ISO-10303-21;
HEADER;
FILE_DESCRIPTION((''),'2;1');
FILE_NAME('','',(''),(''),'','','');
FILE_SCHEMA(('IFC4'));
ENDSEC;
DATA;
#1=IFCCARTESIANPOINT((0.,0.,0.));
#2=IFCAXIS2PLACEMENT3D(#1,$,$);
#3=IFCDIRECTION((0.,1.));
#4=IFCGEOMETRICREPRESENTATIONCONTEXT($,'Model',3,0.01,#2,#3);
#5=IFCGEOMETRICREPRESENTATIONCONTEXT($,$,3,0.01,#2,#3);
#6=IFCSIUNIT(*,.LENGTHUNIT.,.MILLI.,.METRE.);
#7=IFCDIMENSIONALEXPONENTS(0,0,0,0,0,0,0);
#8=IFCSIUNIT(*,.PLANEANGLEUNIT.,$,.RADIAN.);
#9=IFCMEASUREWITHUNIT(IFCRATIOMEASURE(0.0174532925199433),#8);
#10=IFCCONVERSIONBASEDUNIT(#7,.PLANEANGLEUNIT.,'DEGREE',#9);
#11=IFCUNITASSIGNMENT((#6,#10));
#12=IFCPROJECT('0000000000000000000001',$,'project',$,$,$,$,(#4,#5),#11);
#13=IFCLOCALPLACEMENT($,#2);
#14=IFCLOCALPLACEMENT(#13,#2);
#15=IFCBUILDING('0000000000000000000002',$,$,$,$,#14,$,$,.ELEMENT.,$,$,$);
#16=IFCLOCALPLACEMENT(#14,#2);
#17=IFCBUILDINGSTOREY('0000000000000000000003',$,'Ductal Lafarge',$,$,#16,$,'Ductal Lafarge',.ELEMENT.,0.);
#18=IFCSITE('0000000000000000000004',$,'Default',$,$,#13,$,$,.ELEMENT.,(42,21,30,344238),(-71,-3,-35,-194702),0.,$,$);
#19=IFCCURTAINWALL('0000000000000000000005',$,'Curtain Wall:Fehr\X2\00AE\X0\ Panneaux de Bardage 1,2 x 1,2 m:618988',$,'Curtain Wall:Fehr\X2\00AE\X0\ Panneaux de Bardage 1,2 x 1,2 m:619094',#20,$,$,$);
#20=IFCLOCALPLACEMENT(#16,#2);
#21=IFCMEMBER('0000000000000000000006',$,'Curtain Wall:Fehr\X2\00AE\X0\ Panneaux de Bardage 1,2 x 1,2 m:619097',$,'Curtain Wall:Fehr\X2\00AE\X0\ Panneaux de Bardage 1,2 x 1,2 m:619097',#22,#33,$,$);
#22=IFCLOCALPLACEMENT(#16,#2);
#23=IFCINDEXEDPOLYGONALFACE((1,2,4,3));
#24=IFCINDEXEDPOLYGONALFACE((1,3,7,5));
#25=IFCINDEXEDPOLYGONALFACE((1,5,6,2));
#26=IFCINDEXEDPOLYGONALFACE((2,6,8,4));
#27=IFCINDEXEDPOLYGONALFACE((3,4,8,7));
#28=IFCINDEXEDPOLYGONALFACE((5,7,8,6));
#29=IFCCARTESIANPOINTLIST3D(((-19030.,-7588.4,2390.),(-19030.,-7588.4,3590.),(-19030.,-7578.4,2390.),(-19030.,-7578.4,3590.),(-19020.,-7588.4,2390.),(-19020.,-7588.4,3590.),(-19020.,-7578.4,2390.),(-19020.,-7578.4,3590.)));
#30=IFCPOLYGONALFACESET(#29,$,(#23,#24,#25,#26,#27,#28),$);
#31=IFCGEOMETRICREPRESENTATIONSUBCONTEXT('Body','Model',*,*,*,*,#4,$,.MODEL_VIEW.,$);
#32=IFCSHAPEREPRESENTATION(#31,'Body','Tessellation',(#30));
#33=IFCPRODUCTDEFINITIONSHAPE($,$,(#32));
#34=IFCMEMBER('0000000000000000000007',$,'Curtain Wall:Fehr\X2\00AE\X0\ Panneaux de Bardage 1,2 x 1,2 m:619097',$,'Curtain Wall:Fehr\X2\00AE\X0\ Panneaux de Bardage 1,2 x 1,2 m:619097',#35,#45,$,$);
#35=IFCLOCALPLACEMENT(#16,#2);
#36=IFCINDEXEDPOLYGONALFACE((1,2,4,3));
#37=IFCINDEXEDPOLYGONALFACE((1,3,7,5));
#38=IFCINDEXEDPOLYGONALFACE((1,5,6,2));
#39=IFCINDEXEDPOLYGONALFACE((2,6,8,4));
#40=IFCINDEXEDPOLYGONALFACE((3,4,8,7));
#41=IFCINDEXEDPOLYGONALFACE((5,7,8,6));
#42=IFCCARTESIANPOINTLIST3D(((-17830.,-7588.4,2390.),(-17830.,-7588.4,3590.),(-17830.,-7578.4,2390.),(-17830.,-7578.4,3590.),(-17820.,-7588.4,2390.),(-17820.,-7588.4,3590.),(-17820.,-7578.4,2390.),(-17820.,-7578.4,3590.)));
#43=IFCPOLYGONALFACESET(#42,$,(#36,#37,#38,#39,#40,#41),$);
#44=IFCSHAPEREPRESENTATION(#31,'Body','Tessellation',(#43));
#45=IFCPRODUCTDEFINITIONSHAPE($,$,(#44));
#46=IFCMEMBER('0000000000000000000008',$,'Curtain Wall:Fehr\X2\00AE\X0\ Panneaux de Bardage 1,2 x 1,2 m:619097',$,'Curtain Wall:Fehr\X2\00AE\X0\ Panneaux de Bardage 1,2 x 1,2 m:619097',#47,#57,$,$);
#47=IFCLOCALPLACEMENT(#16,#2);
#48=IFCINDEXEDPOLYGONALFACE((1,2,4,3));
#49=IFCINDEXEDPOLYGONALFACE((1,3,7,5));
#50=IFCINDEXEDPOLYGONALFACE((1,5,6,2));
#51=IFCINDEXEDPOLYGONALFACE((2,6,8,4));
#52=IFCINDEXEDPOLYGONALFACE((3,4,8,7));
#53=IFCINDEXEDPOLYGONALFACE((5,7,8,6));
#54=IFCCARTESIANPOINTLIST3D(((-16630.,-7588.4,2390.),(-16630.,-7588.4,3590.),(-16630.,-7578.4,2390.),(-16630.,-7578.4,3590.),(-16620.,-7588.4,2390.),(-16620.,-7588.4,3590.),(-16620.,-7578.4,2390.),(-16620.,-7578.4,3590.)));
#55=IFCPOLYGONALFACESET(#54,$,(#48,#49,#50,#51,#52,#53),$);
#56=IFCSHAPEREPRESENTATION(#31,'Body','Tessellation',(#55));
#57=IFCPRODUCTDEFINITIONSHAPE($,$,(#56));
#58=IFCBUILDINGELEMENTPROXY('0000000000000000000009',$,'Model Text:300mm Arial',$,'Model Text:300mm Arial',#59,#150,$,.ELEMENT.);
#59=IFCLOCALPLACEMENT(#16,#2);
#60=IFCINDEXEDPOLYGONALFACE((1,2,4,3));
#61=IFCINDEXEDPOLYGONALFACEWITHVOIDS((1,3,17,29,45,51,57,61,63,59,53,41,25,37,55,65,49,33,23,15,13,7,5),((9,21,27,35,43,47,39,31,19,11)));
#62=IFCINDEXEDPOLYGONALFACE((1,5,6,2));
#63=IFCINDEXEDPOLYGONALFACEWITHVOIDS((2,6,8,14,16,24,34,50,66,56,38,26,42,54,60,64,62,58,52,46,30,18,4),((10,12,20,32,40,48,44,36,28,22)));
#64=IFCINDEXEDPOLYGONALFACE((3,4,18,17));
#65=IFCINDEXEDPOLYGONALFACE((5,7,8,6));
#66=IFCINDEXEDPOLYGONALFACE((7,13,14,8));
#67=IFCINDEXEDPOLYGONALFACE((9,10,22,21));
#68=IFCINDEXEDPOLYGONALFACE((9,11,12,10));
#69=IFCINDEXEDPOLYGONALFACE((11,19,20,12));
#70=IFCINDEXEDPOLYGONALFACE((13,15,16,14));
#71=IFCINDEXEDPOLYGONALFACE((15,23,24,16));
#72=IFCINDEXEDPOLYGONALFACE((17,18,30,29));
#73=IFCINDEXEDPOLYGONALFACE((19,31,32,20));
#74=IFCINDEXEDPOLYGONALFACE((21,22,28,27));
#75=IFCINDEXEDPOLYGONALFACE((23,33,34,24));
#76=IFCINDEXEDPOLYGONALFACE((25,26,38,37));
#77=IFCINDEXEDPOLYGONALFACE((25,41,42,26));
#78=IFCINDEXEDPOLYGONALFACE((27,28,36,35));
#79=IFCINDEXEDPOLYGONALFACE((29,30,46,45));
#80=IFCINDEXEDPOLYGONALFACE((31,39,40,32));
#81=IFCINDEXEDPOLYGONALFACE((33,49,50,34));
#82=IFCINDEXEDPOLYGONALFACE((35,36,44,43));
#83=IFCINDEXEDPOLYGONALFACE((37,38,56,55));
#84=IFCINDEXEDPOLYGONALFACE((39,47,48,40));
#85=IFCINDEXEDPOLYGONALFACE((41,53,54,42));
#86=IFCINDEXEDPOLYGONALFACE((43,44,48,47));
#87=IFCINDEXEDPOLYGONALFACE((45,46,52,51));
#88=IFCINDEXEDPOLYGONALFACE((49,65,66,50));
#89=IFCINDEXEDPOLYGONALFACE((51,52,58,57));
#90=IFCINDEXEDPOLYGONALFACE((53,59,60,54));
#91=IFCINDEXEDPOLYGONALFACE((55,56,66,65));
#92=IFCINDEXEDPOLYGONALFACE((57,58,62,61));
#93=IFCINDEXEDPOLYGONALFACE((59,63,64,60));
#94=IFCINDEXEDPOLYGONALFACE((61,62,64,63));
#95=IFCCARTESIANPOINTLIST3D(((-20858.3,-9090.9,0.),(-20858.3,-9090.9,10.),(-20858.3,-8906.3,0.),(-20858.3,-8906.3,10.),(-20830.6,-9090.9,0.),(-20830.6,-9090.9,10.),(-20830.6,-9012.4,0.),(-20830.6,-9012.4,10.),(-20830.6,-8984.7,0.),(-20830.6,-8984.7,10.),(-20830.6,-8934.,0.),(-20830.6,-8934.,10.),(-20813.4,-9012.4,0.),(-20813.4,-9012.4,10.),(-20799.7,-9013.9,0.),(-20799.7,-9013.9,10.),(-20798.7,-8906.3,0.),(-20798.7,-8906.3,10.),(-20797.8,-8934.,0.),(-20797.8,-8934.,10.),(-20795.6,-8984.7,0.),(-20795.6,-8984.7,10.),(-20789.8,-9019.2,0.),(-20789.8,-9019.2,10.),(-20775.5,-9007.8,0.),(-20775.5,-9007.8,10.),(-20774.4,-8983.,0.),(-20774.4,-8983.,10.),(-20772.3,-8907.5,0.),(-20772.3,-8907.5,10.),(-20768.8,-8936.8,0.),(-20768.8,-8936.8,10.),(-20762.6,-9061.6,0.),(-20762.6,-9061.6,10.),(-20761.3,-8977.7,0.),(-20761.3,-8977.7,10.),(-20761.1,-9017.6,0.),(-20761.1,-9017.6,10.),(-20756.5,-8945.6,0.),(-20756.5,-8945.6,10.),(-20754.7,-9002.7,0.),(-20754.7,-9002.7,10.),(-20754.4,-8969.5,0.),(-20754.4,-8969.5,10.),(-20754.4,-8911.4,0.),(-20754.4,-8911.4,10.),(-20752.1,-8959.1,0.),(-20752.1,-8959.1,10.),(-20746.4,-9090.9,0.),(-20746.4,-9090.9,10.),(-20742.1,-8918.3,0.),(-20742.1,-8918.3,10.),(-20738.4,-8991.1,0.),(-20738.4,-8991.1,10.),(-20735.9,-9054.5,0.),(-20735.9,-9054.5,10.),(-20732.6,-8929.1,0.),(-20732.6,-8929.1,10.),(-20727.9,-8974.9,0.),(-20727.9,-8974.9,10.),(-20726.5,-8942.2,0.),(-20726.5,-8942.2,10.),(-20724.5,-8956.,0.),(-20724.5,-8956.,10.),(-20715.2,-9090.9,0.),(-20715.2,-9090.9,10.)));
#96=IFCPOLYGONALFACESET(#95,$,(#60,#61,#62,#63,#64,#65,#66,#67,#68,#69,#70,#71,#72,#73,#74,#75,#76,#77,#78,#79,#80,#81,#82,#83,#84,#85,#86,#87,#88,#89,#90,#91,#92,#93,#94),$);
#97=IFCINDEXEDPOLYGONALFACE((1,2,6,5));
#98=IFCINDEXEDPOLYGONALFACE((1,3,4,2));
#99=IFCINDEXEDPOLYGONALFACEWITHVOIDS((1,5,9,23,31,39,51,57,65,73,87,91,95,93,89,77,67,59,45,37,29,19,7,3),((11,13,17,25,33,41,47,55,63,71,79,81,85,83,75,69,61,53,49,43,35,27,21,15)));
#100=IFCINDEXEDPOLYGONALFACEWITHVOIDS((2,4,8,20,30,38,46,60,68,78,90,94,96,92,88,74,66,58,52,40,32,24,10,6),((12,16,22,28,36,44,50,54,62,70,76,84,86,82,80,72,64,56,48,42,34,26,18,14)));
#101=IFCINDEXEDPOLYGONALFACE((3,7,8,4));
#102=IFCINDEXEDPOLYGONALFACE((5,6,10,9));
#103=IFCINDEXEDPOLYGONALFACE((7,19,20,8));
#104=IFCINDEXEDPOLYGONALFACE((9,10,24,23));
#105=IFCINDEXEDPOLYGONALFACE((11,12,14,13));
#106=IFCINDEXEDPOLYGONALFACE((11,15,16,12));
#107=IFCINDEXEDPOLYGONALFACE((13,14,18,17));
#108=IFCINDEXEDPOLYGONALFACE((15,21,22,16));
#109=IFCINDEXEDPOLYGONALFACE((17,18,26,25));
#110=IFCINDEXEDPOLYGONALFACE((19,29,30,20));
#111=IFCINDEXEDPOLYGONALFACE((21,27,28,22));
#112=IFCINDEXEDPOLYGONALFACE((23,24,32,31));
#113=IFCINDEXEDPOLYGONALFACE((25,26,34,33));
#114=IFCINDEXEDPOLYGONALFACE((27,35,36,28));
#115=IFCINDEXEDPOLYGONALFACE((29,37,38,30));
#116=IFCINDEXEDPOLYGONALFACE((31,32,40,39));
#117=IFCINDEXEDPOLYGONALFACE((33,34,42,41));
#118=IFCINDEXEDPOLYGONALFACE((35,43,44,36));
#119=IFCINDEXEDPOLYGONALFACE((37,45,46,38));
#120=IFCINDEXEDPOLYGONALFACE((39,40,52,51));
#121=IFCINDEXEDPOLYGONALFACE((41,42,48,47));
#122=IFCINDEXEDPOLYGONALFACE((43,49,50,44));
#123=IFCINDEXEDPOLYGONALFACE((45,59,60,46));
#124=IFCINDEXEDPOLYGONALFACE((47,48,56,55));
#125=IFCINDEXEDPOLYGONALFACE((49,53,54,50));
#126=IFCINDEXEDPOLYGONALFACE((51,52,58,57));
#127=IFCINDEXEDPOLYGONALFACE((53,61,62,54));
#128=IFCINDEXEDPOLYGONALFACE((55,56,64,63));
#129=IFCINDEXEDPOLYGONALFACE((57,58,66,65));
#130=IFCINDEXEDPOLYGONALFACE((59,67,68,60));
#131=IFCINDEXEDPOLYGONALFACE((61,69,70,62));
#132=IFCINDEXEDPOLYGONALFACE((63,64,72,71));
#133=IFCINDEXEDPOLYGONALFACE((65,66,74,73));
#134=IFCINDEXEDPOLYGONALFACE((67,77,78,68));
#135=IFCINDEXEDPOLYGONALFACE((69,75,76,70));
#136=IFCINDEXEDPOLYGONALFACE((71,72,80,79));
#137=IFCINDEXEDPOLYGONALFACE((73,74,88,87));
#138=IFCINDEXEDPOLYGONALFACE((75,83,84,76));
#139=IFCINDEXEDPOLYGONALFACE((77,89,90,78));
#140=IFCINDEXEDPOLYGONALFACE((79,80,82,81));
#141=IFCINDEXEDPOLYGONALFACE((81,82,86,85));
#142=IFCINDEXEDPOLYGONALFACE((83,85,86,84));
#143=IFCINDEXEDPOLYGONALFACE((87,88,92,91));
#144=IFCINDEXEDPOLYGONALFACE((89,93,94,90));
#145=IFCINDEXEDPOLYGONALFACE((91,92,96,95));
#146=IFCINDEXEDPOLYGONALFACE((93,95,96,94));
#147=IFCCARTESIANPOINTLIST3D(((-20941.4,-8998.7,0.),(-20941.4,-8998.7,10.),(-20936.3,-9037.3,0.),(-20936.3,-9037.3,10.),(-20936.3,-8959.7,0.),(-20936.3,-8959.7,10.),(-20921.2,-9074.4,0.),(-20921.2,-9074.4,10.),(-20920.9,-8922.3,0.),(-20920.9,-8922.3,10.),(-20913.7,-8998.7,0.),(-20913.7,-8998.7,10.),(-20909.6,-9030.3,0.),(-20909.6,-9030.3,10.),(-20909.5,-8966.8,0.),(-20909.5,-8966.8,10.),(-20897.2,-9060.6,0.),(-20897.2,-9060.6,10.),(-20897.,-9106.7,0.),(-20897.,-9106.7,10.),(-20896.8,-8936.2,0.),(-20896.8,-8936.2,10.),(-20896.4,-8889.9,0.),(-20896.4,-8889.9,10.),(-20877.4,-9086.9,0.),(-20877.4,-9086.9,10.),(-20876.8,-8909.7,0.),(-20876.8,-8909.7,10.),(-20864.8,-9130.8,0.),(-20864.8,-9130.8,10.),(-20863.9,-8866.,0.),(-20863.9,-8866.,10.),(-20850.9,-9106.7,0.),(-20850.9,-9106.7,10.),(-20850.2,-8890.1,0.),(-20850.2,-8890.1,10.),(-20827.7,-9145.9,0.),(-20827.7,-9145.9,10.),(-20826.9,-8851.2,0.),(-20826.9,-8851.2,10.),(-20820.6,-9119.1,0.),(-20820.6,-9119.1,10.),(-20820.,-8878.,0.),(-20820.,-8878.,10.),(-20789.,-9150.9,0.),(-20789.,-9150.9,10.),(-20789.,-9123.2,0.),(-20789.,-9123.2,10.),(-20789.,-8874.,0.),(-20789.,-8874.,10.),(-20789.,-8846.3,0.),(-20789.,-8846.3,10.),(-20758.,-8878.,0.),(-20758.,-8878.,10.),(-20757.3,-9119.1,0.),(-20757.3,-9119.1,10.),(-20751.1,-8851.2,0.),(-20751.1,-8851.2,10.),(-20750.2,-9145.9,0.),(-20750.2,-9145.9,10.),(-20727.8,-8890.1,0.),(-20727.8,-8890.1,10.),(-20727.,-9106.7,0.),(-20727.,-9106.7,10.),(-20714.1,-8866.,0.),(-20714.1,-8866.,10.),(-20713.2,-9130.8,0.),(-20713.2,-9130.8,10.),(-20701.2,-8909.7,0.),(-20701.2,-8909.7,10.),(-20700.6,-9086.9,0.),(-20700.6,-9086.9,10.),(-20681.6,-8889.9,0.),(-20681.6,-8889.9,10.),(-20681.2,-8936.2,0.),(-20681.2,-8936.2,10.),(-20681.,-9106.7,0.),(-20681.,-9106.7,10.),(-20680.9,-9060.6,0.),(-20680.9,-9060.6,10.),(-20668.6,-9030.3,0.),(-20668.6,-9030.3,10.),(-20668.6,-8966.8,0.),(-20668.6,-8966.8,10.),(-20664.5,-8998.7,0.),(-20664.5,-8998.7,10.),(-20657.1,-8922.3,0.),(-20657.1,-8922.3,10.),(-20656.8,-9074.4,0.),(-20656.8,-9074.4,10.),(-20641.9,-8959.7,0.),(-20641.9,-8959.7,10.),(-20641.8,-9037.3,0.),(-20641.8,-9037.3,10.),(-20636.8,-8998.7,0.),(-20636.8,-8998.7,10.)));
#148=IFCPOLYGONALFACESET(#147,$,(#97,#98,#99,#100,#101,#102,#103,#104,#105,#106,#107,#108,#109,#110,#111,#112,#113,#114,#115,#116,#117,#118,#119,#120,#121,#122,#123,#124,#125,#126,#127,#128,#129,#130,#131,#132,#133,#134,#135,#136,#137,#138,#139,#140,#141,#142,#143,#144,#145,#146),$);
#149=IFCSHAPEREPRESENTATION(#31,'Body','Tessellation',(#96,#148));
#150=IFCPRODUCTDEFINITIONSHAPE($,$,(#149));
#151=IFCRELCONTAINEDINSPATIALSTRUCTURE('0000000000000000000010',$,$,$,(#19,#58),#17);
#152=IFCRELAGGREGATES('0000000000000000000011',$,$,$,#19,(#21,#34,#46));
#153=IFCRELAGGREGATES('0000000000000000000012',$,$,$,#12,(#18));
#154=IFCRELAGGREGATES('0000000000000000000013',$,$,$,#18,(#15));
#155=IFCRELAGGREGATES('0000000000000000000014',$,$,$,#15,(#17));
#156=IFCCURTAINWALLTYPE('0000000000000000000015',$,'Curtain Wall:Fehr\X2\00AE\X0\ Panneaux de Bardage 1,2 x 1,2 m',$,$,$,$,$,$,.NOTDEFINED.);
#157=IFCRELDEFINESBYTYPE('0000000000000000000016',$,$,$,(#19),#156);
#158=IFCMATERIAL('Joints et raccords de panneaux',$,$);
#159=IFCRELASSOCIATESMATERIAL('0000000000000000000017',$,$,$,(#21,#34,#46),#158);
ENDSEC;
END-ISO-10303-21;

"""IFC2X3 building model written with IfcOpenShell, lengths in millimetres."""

from ifc_helpers import new_model, entity, si_unit, converted_unit, direction, frame, origin, origin_2d_with_axis, place, context, subcontext, project, spatial, polyline, rectangle, outline, extrude, material, type_object, element, aggregate, save


model = new_model("IFC2X3")

# Units and contexts
model_context = context("Model", 3, precision=0.01, world=origin(), true_north=direction((0.0, 1.0)))
context_of_model = context(None, 3, precision=0.01, world=origin(), true_north=direction((0.0, 1.0)))
body_context = subcontext(model_context, "Body", "Model", "MODEL_VIEW")
ifc_project = project(units=[si_unit("LENGTHUNIT", "METRE", prefix="MILLI"), converted_unit("PLANEANGLEUNIT", "DEGREE", entity("IfcRatioMeasure", 0.0174532925199433), si_unit("PLANEANGLEUNIT", "RADIAN"), dimensions=[0, 0, 0, 0, 0, 0, 0])], contexts=[model_context, context_of_model])

# Site, building, storey
site_placement = place(None, origin())
site = spatial("IfcSite", under=ifc_project, at=site_placement, Name="Default", CompositionType="ELEMENT", RefLatitude=(42, 21, 30, 344238), RefLongitude=(-71, -3, -35, -194702), RefElevation=0.0)
building_placement = place(site_placement, origin())
building = spatial("IfcBuilding", under=site, at=building_placement, CompositionType="ELEMENT")
storey_placement = place(building_placement, origin())
storey = spatial("IfcBuildingStorey", under=building, at=storey_placement, Name="Ductal Lafarge", LongName="Ductal Lafarge", CompositionType="ELEMENT", Elevation=0.0)

# Curtain wall, members
curtain_wall_type = type_object("IfcCurtainWallType", Name="Curtain Wall:Fehr® Panneaux de Bardage 1,2 x 1,2 m", PredefinedType="NOTDEFINED")
curtain_wall_placement = place(storey_placement, origin())
curtain_wall = element("IfcCurtainWall", 1, at=curtain_wall_placement, inside=storey, type_object=curtain_wall_type, Name="Curtain Wall:Fehr® Panneaux de Bardage 1,2 x 1,2 m:618988", ObjectType="Curtain Wall:Fehr® Panneaux de Bardage 1,2 x 1,2 m:619094")
ifc_material = material(Name="Joints et raccords de panneaux")
member_1_placement = place(curtain_wall_placement, frame((-19030.0, -7588.4, 2390.0)))
member_1 = element("IfcMember", 2, at=member_1_placement, material=ifc_material, Name="Curtain Wall:Fehr® Panneaux de Bardage 1,2 x 1,2 m:619097", ObjectType="Curtain Wall:Fehr® Panneaux de Bardage 1,2 x 1,2 m:619097", context=body_context, shape_type="SweptSolid", body=[
    extrude(rectangle(XDim=10.0, YDim=10.0, at=origin_2d_with_axis()), frame((5.0, 5.0, 0.0), z_axis=(0.0, 0.0, 1.0), x_axis=(0.0, 1.0, 0.0)), (0.0, 0.0, 1.0), 1200.0),
])
member_2_placement = place(curtain_wall_placement, frame((-17830.0, -7588.4, 2390.0)))
member_2 = element("IfcMember", 3, at=member_2_placement, material=ifc_material, Name="Curtain Wall:Fehr® Panneaux de Bardage 1,2 x 1,2 m:619097", ObjectType="Curtain Wall:Fehr® Panneaux de Bardage 1,2 x 1,2 m:619097", context=body_context, shape_type="SweptSolid", body=[
    extrude(rectangle(XDim=10.0, YDim=10.0, at=origin_2d_with_axis()), frame((5.0, 5.0, 0.0), z_axis=(0.0, 0.0, 1.0), x_axis=(0.0, 1.0, 0.0)), (0.0, 0.0, 1.0), 1200.0),
])
member_3_placement = place(curtain_wall_placement, frame((-16630.0, -7588.4, 2390.0)))
member_3 = element("IfcMember", 4, at=member_3_placement, material=ifc_material, Name="Curtain Wall:Fehr® Panneaux de Bardage 1,2 x 1,2 m:619097", ObjectType="Curtain Wall:Fehr® Panneaux de Bardage 1,2 x 1,2 m:619097", context=body_context, shape_type="SweptSolid", body=[
    extrude(rectangle(XDim=10.0, YDim=10.0, at=origin_2d_with_axis()), frame((5.0, 5.0, 0.0), z_axis=(0.0, 0.0, 1.0), x_axis=(0.0, 1.0, 0.0)), (0.0, 0.0, 1.0), 1200.0),
])
aggregate(curtain_wall, [member_1, member_2, member_3])

# Building element proxy
proxy_1_placement = place(storey_placement, frame((-20941.4, -9150.9, 0.0)))
element("IfcBuildingElementProxy", 5, at=proxy_1_placement, inside=storey, Name="Model Text:300mm Arial", ObjectType="Model Text:300mm Arial", CompositionType="ELEMENT", context=body_context, shape_type="SweptSolid", body=[
    extrude(outline(polyline([(-86.6, -94.9), (-58.9, -94.9), (-58.9, -16.4), (-41.7, -16.4), (-28.0, -17.8), (-18.1, -23.2), (9.1, -65.6), (25.3, -94.9), (56.5, -94.9), (35.8, -58.4), (10.6, -21.6), (-3.8, -11.8), (17.0, -6.7), (33.3, 5.0), (43.8, 21.2), (47.3, 40.0), (45.2, 53.9), (39.1, 66.9), (29.6, 77.7), (17.3, 84.7), (-0.6, 88.5), (-26.9, 89.8), (-86.6, 89.8), (-86.6, -94.9)]), holes=[polyline([(-58.9, 11.3), (-58.9, 62.1), (-26.1, 62.1), (2.9, 59.2), (15.2, 50.4), (19.6, 37.0), (17.3, 26.5), (10.4, 18.3), (-2.7, 13.1), (-23.8, 11.3), (-58.9, 11.3)])]), frame((169.7, 154.9, 0.0)), (0.0, 0.0, 1.0), 10.0),
    extrude(outline(polyline([(-19.6, -150.9), (18.6, -150.9), (57.1, -141.0), (92.5, -121.5), (121.0, -92.5), (141.0, -57.4), (151.1, -19.4), (151.1, 19.5), (140.9, 58.3), (121.0, 93.4), (92.2, 121.5), (57.4, 141.2), (19.6, 151.2), (-19.4, 151.2), (-58.1, 141.0), (-93.2, 121.2), (-121.3, 92.3), (-141.0, 57.5), (-150.9, 19.8), (-150.9, -19.4), (-140.6, -58.5), (-120.5, -93.8), (-91.4, -121.7), (-56.6, -141.1), (-19.6, -150.9)]), holes=[polyline([(-16.1, -123.4), (-46.2, -115.4), (-74.7, -99.6), (-98.5, -76.7), (-114.9, -47.8), (-123.4, -15.8), (-123.5, 16.3), (-115.3, 47.1), (-99.2, 75.5), (-76.2, 99.1), (-47.5, 115.3), (-15.8, 123.7), (16.1, 123.7), (46.9, 115.6), (75.4, 99.4), (99.0, 76.3), (115.3, 47.7), (123.7, 16.0), (123.7, -15.9), (115.4, -46.9), (98.9, -75.6), (75.6, -99.3), (46.7, -115.3), (15.2, -123.4), (-16.1, -123.4)])]), frame((152.4, 152.5, 0.0), z_axis=(0.0, 0.0, 1.0), x_axis=(-0.991656, -0.128915, 0.0)), (0.0, 0.0, 1.0), 10.0),
])

save(model, "model.ifc")
